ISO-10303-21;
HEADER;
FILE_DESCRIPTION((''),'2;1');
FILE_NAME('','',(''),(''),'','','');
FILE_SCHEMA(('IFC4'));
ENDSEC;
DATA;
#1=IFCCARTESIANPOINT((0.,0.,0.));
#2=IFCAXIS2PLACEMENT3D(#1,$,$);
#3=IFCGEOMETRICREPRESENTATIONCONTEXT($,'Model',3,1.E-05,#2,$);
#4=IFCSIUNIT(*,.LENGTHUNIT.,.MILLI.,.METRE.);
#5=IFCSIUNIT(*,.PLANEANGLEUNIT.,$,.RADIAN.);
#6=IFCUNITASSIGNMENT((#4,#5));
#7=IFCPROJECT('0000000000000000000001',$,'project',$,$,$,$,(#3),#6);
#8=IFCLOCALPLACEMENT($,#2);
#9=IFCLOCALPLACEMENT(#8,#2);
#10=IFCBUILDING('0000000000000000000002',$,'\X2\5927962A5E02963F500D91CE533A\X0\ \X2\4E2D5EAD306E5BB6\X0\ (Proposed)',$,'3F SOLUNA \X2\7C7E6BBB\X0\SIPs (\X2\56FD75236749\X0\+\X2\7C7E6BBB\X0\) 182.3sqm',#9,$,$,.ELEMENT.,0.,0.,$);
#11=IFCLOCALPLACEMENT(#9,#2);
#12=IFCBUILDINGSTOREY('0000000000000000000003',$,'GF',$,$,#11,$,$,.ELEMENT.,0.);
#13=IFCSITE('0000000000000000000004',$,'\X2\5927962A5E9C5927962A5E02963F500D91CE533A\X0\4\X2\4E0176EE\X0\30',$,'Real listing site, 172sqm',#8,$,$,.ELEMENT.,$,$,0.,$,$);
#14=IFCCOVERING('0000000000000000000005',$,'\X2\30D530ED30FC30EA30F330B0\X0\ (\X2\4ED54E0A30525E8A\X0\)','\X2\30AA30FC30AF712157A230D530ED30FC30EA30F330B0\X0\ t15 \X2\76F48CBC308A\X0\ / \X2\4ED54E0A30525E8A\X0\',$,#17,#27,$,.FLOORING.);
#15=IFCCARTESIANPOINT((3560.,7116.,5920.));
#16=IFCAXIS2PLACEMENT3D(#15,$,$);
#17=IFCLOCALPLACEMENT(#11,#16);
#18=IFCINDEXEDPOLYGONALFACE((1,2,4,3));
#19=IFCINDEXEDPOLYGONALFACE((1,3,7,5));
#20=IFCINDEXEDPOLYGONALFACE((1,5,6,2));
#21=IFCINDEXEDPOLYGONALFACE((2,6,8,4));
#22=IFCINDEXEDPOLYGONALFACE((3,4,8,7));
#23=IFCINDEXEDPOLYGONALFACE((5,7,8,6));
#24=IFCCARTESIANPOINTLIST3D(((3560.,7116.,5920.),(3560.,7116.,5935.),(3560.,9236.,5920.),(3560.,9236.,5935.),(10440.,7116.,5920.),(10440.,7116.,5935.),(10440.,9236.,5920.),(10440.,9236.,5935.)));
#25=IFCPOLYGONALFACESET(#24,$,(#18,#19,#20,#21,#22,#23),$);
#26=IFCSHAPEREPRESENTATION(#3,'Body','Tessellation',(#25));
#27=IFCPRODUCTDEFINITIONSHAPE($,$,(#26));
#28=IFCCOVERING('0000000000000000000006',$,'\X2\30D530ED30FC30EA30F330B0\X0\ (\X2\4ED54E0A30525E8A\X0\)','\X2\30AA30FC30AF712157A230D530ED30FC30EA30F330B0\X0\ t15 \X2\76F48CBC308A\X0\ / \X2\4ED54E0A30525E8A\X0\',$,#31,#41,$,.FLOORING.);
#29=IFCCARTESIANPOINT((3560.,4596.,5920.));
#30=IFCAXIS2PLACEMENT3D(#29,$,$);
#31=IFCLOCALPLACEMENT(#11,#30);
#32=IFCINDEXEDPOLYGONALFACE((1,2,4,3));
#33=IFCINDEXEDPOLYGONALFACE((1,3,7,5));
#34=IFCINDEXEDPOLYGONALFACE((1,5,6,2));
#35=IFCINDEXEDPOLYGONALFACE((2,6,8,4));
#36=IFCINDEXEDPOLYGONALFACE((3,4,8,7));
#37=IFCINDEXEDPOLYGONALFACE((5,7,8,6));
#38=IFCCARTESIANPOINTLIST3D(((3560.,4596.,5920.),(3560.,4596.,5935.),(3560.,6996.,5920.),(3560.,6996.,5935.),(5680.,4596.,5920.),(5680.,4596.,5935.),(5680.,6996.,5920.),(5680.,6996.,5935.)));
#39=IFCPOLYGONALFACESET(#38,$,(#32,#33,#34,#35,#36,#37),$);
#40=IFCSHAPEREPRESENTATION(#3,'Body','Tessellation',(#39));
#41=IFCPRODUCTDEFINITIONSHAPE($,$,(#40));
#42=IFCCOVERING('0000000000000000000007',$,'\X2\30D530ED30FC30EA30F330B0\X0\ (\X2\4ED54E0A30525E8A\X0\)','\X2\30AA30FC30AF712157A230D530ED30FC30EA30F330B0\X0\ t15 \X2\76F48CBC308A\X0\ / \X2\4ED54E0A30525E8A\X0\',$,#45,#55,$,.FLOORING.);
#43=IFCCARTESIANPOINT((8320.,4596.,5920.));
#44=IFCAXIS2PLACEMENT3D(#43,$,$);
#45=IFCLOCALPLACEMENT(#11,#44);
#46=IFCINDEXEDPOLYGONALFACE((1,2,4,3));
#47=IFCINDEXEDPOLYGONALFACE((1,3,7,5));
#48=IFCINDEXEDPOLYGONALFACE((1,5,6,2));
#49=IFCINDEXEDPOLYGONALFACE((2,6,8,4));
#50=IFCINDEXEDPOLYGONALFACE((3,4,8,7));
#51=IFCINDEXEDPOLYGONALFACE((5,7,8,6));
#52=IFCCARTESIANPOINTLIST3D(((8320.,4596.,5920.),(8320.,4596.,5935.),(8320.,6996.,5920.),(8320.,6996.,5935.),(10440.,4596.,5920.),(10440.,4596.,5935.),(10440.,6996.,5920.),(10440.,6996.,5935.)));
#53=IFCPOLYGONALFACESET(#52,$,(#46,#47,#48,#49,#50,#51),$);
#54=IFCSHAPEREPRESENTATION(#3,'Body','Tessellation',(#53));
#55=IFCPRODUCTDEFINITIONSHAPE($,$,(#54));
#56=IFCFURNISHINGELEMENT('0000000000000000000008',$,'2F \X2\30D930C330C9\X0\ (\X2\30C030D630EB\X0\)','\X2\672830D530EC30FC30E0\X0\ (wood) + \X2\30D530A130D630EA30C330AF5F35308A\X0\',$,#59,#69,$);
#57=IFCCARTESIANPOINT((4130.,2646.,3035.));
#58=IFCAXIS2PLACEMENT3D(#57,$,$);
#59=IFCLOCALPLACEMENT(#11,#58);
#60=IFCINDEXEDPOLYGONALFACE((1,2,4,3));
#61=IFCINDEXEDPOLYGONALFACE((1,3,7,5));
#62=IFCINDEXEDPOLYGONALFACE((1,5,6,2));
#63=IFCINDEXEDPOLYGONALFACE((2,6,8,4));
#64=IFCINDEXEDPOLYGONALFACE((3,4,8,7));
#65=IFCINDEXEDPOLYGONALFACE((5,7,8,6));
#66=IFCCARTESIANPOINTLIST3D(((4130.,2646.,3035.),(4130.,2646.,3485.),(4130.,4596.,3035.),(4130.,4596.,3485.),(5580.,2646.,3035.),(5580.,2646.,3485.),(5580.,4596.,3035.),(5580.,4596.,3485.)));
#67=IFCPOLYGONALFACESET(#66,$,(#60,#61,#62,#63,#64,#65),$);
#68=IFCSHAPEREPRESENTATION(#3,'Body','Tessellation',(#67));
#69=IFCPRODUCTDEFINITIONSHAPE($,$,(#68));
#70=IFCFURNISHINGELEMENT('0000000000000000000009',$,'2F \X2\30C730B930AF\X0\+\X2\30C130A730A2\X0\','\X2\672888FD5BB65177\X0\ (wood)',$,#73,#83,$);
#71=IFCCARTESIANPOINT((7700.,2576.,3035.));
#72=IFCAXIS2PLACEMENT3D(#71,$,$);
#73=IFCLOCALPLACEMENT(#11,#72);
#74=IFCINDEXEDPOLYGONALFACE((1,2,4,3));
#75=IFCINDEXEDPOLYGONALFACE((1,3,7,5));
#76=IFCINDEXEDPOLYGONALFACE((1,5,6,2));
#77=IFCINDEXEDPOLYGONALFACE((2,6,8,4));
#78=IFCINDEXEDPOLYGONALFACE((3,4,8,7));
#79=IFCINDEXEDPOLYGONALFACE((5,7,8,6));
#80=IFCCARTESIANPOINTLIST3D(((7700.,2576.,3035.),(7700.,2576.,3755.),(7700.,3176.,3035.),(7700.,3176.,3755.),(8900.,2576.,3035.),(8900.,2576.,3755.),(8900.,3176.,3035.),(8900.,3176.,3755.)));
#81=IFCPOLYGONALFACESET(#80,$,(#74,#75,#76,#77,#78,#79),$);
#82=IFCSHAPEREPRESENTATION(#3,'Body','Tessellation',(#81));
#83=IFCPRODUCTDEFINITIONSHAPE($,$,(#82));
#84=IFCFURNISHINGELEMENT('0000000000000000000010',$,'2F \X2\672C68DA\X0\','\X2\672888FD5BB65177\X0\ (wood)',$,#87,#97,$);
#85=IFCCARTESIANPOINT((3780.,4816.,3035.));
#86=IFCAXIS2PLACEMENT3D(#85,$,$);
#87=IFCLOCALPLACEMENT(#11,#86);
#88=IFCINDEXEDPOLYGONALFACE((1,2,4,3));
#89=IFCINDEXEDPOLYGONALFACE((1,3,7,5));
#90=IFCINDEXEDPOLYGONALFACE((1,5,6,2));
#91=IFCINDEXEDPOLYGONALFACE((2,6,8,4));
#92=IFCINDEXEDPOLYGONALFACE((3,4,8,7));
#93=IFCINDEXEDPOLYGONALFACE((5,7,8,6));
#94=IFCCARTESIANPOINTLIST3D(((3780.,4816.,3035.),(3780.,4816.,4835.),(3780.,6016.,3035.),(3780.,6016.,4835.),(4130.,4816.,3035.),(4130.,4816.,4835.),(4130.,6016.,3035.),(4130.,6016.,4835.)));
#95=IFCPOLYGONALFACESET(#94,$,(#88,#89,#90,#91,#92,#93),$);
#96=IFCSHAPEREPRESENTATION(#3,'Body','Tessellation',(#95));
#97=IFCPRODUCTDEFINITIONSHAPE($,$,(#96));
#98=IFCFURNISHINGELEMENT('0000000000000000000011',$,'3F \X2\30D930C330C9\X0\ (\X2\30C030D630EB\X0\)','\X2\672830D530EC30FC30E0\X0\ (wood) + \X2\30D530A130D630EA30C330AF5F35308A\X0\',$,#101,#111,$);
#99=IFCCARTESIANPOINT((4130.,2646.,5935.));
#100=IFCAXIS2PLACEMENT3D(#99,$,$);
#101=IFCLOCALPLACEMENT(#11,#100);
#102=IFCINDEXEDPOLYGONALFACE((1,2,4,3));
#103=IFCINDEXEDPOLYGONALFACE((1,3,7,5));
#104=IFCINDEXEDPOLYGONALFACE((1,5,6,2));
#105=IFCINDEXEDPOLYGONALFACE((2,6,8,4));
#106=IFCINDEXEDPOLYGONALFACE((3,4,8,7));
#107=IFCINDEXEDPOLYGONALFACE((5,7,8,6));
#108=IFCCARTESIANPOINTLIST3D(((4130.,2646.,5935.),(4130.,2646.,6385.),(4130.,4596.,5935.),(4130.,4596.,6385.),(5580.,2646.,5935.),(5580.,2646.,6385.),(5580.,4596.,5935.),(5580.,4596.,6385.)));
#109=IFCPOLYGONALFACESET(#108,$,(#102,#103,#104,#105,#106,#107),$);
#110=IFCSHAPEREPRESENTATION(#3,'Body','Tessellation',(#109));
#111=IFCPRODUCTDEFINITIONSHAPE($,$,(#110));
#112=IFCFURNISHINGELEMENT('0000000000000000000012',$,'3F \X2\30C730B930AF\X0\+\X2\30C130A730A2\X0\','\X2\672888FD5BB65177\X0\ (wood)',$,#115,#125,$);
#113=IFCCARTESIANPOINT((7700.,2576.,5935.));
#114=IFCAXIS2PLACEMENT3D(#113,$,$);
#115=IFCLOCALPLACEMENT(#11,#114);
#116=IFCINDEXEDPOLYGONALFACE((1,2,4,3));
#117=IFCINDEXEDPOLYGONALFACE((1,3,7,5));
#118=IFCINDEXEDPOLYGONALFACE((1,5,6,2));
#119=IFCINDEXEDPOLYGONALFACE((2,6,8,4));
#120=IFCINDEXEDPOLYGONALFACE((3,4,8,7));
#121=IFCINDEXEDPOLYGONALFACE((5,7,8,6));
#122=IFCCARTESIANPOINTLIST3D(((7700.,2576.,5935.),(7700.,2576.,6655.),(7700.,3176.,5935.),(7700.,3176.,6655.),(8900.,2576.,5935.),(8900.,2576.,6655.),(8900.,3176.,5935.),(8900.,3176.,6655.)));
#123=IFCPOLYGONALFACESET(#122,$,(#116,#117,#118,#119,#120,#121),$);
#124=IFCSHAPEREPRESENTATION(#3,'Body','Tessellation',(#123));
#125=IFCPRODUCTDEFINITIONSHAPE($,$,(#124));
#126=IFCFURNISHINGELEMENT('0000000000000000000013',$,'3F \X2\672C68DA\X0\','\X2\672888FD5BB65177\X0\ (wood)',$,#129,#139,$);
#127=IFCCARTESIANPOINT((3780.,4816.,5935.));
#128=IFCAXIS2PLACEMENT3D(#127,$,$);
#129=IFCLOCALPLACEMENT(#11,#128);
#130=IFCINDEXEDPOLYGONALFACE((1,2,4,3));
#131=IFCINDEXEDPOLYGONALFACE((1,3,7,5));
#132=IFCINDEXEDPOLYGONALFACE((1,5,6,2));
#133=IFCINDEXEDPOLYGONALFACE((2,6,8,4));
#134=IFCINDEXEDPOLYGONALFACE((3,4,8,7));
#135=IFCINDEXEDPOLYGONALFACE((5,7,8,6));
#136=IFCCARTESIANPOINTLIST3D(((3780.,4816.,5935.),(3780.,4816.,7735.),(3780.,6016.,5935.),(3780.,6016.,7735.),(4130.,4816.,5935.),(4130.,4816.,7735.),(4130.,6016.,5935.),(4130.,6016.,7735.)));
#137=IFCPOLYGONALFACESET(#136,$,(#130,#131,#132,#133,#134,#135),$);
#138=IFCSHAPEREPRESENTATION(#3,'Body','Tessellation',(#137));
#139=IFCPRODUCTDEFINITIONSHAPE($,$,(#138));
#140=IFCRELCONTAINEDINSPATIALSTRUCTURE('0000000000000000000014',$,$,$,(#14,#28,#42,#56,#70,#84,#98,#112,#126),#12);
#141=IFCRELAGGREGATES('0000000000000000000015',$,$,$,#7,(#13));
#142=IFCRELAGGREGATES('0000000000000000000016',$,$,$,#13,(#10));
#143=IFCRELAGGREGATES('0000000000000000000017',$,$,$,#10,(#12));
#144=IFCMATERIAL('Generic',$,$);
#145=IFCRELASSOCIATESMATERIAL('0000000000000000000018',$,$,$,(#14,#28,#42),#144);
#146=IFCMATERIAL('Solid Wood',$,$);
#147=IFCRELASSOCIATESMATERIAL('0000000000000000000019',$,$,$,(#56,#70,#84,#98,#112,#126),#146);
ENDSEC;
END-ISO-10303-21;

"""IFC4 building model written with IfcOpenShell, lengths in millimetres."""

from ifc_helpers import new_model, si_unit, frame, frame_2d, origin, place, context, project, spatial, rectangle, extrude, material, element, save


model = new_model("IFC4")

# Units and contexts
model_context = context("Model", 3, precision=1e-05, world=origin())
ifc_project = project(units=[si_unit("LENGTHUNIT", "METRE", prefix="MILLI"), si_unit("PLANEANGLEUNIT", "RADIAN")], contexts=[model_context])

# Site, building, storey
site_placement = place(None, origin())
site = spatial("IfcSite", under=ifc_project, at=site_placement, Name="大阪府大阪市阿倍野区4丁目30", ObjectType="Real listing site, 172sqm", CompositionType="ELEMENT", RefElevation=0.0)
building_placement = place(site_placement, origin())
building = spatial("IfcBuilding", under=site, at=building_placement, Name="大阪市阿倍野区 中庭の家 (Proposed)", ObjectType="3F SOLUNA 籾殻SIPs (国産杉+籾殻) 182.3sqm", CompositionType="ELEMENT", ElevationOfRefHeight=0.0, ElevationOfTerrain=0.0)
storey_placement = place(building_placement, origin())
storey = spatial("IfcBuildingStorey", under=building, at=storey_placement, Name="GF", CompositionType="ELEMENT", Elevation=0.0)

# Shared definitions
ifc_material_1 = material(Name="Solid Wood")

# Shared definitions
ifc_material_2 = material(Name="Generic")

# Coverings
covering_1_placement = place(storey_placement, frame((3560.0, 7116.0, 5920.0)))
element("IfcCovering", 1, at=covering_1_placement, inside=storey, material=ifc_material_2, Name="フローリング (仕上げ床)", Description="オーク無垢フローリング t15 直貼り / 仕上げ床", PredefinedType="FLOORING", context=model_context, shape_type="SweptSolid", body=[
    extrude(rectangle(XDim=6880.0, YDim=2120.0, at=frame_2d((3440.0, 1060.0))), frame((3560.0, 7116.0, 5920.0)), (0.0, 0.0, 1.0), 15.0),
])
covering_2_placement = place(storey_placement, frame((3560.0, 4596.0, 5920.0)))
element("IfcCovering", 2, at=covering_2_placement, inside=storey, material=ifc_material_2, Name="フローリング (仕上げ床)", Description="オーク無垢フローリング t15 直貼り / 仕上げ床", PredefinedType="FLOORING", context=model_context, shape_type="SweptSolid", body=[
    extrude(rectangle(XDim=2120.0, YDim=2400.0, at=frame_2d((1060.0, 1200.0))), frame((3560.0, 4596.0, 5920.0)), (0.0, 0.0, 1.0), 15.0),
])
covering_3_placement = place(storey_placement, frame((8320.0, 4596.0, 5920.0)))
element("IfcCovering", 3, at=covering_3_placement, inside=storey, material=ifc_material_2, Name="フローリング (仕上げ床)", Description="オーク無垢フローリング t15 直貼り / 仕上げ床", PredefinedType="FLOORING", context=model_context, shape_type="SweptSolid", body=[
    extrude(rectangle(XDim=2120.0, YDim=2400.0, at=frame_2d((1060.0, 1200.0))), frame((8320.0, 4596.0, 5920.0)), (0.0, 0.0, 1.0), 15.0),
])

# Furnishing elements
furnishing_1_placement = place(storey_placement, frame((4130.0, 2646.0, 3035.0)))
element("IfcFurnishingElement", 4, at=furnishing_1_placement, inside=storey, material=ifc_material_1, Name="2F ベッド (ダブル)", Description="木フレーム (wood) + ファブリック張り", context=model_context, shape_type="SweptSolid", body=[
    extrude(rectangle(XDim=1450.0, YDim=1950.0, at=frame_2d((725.0, 975.0))), frame((4130.0, 2646.0, 3035.0)), (0.0, 0.0, 1.0), 450.0),
])
furnishing_2_placement = place(storey_placement, frame((7700.0, 2576.0, 3035.0)))
element("IfcFurnishingElement", 5, at=furnishing_2_placement, inside=storey, material=ifc_material_1, Name="2F デスク+チェア", Description="木製家具 (wood)", context=model_context, shape_type="SweptSolid", body=[
    extrude(rectangle(XDim=1200.0, YDim=600.0, at=frame_2d((600.0, 300.0))), frame((7700.0, 2576.0, 3035.0)), (0.0, 0.0, 1.0), 720.0),
])
furnishing_3_placement = place(storey_placement, frame((3780.0, 4816.0, 3035.0)))
element("IfcFurnishingElement", 6, at=furnishing_3_placement, inside=storey, material=ifc_material_1, Name="2F 本棚", Description="木製家具 (wood)", context=model_context, shape_type="SweptSolid", body=[
    extrude(rectangle(XDim=350.0, YDim=1200.0, at=frame_2d((175.0, 600.0))), frame((3780.0, 4816.0, 3035.0)), (0.0, 0.0, 1.0), 1800.0),
])
furnishing_4_placement = place(storey_placement, frame((4130.0, 2646.0, 5935.0)))
element("IfcFurnishingElement", 7, at=furnishing_4_placement, inside=storey, material=ifc_material_1, Name="3F ベッド (ダブル)", Description="木フレーム (wood) + ファブリック張り", context=model_context, shape_type="SweptSolid", body=[
    extrude(rectangle(XDim=1450.0, YDim=1950.0, at=frame_2d((725.0, 975.0))), frame((4130.0, 2646.0, 5935.0)), (0.0, 0.0, 1.0), 450.0),
])
furnishing_5_placement = place(storey_placement, frame((7700.0, 2576.0, 5935.0)))
element("IfcFurnishingElement", 8, at=furnishing_5_placement, inside=storey, material=ifc_material_1, Name="3F デスク+チェア", Description="木製家具 (wood)", context=model_context, shape_type="SweptSolid", body=[
    extrude(rectangle(XDim=1200.0, YDim=600.0, at=frame_2d((600.0, 300.0))), frame((7700.0, 2576.0, 5935.0)), (0.0, 0.0, 1.0), 720.0),
])
furnishing_6_placement = place(storey_placement, frame((3780.0, 4816.0, 5935.0)))
element("IfcFurnishingElement", 9, at=furnishing_6_placement, inside=storey, material=ifc_material_1, Name="3F 本棚", Description="木製家具 (wood)", context=model_context, shape_type="SweptSolid", body=[
    extrude(rectangle(XDim=350.0, YDim=1200.0, at=frame_2d((175.0, 600.0))), frame((3780.0, 4816.0, 5935.0)), (0.0, 0.0, 1.0), 1800.0),
])

save(model, "model.ifc")
